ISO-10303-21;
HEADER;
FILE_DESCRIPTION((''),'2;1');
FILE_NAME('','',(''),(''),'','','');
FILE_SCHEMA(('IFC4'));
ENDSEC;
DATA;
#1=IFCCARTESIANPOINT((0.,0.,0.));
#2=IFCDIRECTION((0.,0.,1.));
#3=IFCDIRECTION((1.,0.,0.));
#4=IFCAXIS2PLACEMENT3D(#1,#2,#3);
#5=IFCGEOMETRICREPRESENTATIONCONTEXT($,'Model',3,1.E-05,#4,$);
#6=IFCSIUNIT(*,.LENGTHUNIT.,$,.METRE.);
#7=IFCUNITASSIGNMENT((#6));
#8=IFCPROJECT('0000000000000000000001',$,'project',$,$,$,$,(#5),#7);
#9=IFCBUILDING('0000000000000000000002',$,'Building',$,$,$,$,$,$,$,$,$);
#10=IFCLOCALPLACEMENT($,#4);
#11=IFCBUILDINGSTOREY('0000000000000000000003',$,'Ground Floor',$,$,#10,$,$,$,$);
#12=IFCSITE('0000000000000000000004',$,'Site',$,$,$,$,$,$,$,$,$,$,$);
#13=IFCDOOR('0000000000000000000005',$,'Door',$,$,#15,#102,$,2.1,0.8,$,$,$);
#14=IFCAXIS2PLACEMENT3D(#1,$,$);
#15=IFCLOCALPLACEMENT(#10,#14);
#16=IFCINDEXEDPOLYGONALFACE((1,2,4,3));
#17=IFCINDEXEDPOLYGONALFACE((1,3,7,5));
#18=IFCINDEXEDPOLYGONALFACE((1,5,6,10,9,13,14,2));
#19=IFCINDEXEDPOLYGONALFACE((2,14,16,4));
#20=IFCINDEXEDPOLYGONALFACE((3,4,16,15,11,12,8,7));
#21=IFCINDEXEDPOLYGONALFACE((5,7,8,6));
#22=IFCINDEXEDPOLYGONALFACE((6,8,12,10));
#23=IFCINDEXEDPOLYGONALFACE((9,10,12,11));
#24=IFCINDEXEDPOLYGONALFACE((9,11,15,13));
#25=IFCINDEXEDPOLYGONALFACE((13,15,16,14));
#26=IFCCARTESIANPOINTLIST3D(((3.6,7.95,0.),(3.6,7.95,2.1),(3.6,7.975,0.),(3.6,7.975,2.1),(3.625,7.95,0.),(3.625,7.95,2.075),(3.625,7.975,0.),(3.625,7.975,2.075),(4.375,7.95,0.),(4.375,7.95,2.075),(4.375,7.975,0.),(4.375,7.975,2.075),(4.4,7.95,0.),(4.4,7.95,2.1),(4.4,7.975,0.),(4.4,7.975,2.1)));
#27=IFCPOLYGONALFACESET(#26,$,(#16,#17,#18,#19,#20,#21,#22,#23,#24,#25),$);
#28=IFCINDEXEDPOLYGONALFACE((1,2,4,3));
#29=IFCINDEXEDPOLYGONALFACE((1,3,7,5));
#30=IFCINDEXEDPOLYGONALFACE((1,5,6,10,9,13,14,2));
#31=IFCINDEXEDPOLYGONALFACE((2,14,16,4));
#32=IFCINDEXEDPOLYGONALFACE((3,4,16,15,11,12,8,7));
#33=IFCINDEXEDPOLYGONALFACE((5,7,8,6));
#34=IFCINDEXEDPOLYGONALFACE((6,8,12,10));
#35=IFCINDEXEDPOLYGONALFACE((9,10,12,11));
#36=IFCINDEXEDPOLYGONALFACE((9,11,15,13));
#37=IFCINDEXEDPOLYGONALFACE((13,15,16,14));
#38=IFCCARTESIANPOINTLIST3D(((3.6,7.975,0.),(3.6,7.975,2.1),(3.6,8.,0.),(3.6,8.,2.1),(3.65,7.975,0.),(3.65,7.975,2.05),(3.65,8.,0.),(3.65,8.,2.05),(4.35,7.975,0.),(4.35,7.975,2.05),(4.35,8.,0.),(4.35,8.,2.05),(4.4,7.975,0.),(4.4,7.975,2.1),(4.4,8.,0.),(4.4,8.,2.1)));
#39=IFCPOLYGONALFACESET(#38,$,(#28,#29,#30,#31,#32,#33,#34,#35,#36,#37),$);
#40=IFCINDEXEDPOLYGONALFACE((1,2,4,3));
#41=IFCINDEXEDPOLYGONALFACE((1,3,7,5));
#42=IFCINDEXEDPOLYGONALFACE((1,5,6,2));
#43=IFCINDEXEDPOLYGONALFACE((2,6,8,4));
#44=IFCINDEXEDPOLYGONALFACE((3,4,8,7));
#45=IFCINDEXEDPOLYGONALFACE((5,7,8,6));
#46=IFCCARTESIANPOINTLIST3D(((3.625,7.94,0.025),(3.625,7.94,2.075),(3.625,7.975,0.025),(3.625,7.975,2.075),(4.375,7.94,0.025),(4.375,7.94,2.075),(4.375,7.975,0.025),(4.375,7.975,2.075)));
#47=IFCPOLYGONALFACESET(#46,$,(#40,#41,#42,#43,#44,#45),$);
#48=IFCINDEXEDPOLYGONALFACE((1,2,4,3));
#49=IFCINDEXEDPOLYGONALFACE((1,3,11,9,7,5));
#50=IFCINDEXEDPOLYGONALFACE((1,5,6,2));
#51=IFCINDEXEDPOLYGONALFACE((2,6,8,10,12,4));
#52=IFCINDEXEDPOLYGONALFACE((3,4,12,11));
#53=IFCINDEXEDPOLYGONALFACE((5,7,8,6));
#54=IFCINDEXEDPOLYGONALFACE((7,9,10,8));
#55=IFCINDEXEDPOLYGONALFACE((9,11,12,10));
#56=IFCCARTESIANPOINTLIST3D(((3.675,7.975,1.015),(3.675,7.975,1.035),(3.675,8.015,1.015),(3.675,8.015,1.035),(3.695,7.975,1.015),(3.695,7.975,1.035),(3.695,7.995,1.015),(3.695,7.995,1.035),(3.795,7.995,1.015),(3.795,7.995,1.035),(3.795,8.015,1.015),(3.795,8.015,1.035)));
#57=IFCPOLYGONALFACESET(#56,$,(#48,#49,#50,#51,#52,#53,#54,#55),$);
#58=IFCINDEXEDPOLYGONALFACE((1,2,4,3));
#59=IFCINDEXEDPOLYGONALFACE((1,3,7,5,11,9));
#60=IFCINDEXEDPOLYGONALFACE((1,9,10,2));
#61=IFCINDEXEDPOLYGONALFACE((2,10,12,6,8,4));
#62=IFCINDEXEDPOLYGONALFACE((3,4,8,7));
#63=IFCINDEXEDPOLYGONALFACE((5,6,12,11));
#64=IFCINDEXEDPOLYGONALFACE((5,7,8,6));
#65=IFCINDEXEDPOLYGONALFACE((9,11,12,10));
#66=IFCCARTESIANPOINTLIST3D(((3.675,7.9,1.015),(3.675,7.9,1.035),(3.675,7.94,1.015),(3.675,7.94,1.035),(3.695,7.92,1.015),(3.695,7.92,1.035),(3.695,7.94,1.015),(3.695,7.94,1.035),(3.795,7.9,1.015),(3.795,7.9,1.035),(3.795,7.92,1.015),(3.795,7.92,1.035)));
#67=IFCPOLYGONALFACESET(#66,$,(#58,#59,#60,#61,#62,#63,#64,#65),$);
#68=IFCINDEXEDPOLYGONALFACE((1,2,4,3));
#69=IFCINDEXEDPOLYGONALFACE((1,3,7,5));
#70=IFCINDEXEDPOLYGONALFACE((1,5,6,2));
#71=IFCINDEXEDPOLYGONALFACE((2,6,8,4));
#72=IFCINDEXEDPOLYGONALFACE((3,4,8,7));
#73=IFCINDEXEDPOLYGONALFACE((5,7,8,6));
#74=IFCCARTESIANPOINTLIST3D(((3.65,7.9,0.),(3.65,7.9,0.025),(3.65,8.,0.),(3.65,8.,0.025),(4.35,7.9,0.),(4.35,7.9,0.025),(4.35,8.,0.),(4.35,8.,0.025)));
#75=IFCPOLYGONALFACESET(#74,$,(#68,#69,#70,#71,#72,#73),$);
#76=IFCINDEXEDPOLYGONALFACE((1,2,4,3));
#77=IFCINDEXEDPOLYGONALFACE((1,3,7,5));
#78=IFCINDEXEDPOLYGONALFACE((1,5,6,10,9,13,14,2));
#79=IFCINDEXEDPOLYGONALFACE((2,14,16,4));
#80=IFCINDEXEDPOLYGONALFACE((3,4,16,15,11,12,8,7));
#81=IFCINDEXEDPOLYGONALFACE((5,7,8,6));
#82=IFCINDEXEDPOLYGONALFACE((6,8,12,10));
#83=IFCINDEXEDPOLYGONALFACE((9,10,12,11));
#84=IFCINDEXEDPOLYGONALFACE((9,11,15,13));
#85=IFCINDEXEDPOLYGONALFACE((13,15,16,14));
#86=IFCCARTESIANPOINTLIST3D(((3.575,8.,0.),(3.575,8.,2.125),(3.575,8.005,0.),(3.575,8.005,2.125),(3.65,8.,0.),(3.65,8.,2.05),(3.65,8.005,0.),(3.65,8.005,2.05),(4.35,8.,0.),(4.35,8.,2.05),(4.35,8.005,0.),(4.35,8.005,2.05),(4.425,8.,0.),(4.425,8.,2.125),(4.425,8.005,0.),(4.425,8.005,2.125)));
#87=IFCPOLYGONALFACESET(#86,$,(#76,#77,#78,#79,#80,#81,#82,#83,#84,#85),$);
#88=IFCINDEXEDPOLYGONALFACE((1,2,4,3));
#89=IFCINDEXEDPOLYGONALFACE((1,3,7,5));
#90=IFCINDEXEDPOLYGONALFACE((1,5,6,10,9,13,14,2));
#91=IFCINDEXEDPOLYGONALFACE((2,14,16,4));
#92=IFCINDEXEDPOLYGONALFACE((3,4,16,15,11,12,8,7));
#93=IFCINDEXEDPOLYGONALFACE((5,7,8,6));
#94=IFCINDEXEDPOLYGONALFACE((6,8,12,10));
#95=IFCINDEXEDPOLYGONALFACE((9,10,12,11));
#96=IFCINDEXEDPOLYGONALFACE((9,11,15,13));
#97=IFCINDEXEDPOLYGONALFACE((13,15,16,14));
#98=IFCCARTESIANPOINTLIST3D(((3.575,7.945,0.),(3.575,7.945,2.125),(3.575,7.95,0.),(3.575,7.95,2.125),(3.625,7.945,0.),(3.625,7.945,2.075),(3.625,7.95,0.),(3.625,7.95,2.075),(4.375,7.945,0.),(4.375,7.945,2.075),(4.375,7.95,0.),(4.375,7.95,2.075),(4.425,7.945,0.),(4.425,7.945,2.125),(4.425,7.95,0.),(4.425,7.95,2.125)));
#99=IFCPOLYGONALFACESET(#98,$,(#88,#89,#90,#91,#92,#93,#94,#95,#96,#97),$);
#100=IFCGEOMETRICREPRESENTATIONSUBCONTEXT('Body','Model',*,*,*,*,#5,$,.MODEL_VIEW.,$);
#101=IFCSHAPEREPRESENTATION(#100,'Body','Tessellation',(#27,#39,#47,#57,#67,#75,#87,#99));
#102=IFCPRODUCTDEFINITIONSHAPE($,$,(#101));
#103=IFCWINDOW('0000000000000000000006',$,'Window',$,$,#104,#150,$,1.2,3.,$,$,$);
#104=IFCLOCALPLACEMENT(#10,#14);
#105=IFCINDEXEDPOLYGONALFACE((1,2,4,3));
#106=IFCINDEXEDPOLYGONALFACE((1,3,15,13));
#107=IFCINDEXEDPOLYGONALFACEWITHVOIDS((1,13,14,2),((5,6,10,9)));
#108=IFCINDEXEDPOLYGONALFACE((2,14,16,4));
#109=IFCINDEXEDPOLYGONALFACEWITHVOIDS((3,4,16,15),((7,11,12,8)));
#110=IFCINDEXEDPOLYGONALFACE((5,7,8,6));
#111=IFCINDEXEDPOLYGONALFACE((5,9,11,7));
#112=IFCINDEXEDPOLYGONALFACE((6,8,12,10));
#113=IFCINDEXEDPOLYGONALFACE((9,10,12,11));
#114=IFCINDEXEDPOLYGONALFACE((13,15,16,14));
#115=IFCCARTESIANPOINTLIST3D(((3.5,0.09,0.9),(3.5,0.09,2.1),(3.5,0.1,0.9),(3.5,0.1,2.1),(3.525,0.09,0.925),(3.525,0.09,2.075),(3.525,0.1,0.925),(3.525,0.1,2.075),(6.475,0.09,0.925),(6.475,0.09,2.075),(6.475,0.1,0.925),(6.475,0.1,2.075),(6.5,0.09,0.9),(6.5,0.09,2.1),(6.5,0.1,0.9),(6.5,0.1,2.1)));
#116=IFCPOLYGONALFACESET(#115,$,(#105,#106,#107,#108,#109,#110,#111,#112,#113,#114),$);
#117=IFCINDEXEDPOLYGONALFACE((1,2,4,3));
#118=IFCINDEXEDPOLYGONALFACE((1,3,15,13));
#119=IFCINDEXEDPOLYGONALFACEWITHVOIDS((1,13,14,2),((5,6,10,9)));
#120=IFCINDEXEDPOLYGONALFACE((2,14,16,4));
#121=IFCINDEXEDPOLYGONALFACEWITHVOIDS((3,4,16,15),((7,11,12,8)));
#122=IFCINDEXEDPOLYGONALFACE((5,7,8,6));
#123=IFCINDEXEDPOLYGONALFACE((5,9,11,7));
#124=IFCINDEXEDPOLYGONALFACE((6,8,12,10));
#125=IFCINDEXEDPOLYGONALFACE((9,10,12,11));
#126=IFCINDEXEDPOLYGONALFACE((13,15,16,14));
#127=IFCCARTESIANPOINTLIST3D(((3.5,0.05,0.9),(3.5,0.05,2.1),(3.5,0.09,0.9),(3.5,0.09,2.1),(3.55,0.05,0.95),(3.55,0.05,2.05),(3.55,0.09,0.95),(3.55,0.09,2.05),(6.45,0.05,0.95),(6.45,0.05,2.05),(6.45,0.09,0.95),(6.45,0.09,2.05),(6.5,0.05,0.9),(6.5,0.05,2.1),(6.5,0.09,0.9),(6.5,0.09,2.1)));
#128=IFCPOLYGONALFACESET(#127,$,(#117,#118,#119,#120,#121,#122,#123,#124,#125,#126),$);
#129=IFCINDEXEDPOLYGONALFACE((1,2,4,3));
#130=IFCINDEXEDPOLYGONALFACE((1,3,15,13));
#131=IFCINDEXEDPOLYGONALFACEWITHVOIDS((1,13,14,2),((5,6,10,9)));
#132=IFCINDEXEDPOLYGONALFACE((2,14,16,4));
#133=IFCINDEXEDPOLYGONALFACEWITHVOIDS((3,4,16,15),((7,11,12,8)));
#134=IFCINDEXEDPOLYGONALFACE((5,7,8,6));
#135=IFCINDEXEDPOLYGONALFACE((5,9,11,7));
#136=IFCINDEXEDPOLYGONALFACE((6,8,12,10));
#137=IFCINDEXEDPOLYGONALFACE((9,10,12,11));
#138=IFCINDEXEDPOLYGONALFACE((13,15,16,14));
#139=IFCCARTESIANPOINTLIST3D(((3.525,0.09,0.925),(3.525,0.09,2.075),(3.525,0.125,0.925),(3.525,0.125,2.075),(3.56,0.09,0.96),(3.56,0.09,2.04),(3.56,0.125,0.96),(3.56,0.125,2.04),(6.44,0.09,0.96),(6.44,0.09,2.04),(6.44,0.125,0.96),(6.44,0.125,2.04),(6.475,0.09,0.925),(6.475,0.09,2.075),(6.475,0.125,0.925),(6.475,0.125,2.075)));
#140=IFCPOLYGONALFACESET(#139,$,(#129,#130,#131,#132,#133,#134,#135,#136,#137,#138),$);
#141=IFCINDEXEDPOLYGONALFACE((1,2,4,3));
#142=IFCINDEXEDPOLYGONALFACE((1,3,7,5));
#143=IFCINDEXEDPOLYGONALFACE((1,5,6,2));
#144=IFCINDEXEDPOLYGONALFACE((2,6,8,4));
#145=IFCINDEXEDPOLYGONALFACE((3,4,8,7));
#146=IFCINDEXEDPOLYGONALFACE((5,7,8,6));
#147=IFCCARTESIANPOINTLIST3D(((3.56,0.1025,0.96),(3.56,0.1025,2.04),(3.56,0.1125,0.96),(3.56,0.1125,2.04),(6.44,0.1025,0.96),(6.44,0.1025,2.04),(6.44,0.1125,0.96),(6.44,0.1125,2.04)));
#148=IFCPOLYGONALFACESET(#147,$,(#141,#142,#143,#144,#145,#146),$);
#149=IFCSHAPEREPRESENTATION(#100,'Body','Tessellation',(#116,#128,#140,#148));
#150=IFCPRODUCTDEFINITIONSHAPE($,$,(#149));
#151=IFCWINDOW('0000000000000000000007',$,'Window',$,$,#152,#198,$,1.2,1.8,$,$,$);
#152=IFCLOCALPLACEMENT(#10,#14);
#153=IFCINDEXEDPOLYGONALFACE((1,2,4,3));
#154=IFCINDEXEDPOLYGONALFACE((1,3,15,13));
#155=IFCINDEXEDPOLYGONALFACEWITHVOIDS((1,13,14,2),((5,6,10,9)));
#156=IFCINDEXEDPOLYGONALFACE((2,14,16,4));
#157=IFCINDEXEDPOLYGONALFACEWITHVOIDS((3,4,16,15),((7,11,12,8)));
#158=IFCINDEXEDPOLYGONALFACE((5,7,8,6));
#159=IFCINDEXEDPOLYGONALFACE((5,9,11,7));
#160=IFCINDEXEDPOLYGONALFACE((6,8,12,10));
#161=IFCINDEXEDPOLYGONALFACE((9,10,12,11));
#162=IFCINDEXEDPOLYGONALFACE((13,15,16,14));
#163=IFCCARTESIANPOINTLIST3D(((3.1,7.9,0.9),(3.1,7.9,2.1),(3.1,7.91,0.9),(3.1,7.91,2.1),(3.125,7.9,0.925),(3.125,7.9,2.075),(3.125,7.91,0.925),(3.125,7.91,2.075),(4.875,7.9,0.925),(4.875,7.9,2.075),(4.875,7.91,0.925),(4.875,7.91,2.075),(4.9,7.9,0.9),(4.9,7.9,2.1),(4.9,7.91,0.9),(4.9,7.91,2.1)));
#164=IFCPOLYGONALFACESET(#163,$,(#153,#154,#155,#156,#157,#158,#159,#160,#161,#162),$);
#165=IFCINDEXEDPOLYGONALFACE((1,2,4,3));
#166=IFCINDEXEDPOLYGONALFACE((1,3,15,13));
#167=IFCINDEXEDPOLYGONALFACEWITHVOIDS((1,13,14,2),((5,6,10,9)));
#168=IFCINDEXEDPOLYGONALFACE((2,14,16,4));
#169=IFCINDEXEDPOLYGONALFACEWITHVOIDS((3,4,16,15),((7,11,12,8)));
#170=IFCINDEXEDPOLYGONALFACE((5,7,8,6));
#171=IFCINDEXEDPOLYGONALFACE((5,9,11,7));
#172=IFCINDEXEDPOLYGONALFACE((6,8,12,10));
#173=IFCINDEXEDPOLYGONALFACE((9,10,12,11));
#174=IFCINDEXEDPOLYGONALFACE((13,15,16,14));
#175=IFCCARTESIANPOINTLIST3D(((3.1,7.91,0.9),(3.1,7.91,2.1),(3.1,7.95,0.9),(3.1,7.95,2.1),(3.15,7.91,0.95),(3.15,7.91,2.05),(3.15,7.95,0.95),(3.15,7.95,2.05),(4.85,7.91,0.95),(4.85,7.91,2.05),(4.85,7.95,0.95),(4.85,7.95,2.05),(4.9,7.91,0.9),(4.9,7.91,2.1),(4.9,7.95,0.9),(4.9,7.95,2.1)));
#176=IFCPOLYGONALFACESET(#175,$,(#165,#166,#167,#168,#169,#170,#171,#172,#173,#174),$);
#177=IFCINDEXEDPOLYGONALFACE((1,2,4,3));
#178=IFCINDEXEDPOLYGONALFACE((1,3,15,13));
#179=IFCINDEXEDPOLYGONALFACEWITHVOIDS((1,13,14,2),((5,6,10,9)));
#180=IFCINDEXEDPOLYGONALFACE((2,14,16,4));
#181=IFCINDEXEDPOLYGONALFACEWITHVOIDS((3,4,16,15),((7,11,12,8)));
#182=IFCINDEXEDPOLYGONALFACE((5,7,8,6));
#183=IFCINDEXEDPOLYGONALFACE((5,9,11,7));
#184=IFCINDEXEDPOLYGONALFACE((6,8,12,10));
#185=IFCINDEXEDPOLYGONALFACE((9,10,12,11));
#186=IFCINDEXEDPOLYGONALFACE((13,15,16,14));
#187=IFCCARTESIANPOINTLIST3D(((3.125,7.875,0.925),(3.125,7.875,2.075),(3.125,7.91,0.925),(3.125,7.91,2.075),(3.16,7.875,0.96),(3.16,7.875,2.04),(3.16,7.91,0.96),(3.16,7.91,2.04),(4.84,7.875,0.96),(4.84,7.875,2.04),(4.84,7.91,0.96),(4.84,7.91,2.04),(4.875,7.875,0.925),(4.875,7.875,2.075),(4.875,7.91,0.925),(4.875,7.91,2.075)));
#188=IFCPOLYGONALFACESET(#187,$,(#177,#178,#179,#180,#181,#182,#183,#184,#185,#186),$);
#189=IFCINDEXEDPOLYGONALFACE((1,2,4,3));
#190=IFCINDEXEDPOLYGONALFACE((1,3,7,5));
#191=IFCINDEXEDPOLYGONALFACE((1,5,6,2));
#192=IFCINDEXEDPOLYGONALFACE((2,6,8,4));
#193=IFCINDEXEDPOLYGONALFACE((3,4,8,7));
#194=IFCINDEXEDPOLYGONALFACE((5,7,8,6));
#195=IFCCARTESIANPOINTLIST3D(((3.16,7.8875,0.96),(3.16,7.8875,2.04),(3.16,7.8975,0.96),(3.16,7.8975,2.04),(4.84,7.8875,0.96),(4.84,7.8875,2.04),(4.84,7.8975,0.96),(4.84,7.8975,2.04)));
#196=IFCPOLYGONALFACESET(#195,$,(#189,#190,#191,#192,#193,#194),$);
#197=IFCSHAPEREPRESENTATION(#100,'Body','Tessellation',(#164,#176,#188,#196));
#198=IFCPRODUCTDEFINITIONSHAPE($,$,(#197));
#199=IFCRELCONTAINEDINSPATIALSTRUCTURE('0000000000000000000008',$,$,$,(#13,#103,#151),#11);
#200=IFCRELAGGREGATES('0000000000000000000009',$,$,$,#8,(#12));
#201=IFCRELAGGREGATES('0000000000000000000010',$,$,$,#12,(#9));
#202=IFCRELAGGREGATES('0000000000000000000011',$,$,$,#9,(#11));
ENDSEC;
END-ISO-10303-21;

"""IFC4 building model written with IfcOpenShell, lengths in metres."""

from ifc_helpers import new_model, si_unit, frame, origin_with_axes, place, context, subcontext, project, spatial, line, indexed_curve, outline, extrude, element, save


model = new_model("IFC4")

# Units and contexts
model_context = context("Model", 3, precision=1e-05, world=origin_with_axes())
body_context = subcontext(model_context, "Body", "Model", "MODEL_VIEW")
ifc_project = project(units=[si_unit("LENGTHUNIT", "METRE")], contexts=[model_context])

# Site, building, storey
site = spatial("IfcSite", under=ifc_project, Name="Site")
building = spatial("IfcBuilding", under=site, Name="Building")
storey_placement = place(None, origin_with_axes())
storey = spatial("IfcBuildingStorey", under=building, at=storey_placement, Name="Ground Floor")

# Door
door_1_placement = place(storey_placement, frame((4.4, 8.0, 0.0), z_axis=(0.0, 0.0, 1.0), x_axis=(-1.0, 0.0, 0.0)))
element("IfcDoor", 1, at=door_1_placement, inside=storey, Name="Door", OverallHeight=2.1, OverallWidth=0.8, context=body_context, shape_type="SweptSolid", body=[
    extrude(outline(indexed_curve([(0.0, 0.0), (0.0, 2.1), (0.8, 2.1), (0.8, 0.0), (0.775, 0.0), (0.775, 2.075), (0.025, 2.075), (0.025, 0.0)], segments=[line(1, 2, 3, 4, 5, 6, 7, 8, 1)])), frame((0.0, 0.025, 0.0), z_axis=(0.0, -1.0, 0.0), x_axis=(1.0, 0.0, 0.0)), (0.0, 0.0, -1.0), 0.025),
    extrude(outline(indexed_curve([(0.0, 0.0), (0.0, 2.1), (0.8, 2.1), (0.8, 0.0), (0.75, 0.0), (0.75, 2.05), (0.05, 2.05), (0.05, 0.0)], segments=[line(1, 2, 3, 4, 5, 6, 7, 8, 1)])), frame((0.0, 0.0, 0.0), z_axis=(0.0, -1.0, 0.0), x_axis=(1.0, 0.0, 0.0)), (0.0, 0.0, -1.0), 0.025),
    extrude(outline(indexed_curve([(0.0, 0.0), (0.75, 0.0), (0.75, 0.035), (0.0, 0.035)], segments=[line(1, 2, 3, 4, 1)])), frame((0.025, 0.025, 0.025), z_axis=(0.0, 0.0, 1.0), x_axis=(1.0, 0.0, 0.0)), (0.0, 0.0, 1.0), 2.05),
    extrude(outline(indexed_curve([(0.0, 0.0), (0.0, -0.04), (-0.12, -0.04), (-0.12, -0.02), (-0.02, -0.02), (-0.02, 0.0)], segments=[line(1, 2, 3, 4, 5, 6, 1)])), frame((0.725, 0.025, 1.015), z_axis=(0.0, 0.0, 1.0), x_axis=(1.0, 0.0, 0.0)), (0.0, 0.0, 1.0), 0.02),
    extrude(outline(indexed_curve([(0.0, 0.0), (0.0, 0.04), (-0.12, 0.04), (-0.12, 0.02), (-0.02, 0.02), (-0.02, 0.0)], segments=[line(1, 2, 3, 4, 5, 6, 1)])), frame((0.725, 0.06, 1.015), z_axis=(0.0, 0.0, 1.0), x_axis=(1.0, 0.0, 0.0)), (0.0, 0.0, 1.0), 0.02),
    extrude(outline(indexed_curve([(0.0, 0.0), (0.7, 0.0), (0.7, 0.1), (0.0, 0.1)], segments=[line(1, 2, 3, 4, 1)])), frame((0.05, 0.0, 0.0), z_axis=(0.0, 0.0, 1.0), x_axis=(1.0, 0.0, 0.0)), (0.0, 0.0, 1.0), 0.025),
    extrude(outline(indexed_curve([(0.0, 0.0), (0.0, 2.125), (0.85, 2.125), (0.85, 0.0), (0.775, 0.0), (0.775, 2.05), (0.075, 2.05), (0.075, 0.0)], segments=[line(1, 2, 3, 4, 5, 6, 7, 8, 1)])), frame((-0.025, -0.005, 0.0), z_axis=(0.0, -1.0, 0.0), x_axis=(1.0, 0.0, 0.0)), (0.0, 0.0, -1.0), 0.005),
    extrude(outline(indexed_curve([(0.0, 0.0), (0.0, 2.125), (0.85, 2.125), (0.85, 0.0), (0.8, 0.0), (0.8, 2.075), (0.05, 2.075), (0.05, 0.0)], segments=[line(1, 2, 3, 4, 5, 6, 7, 8, 1)])), frame((-0.025, 0.05, 0.0), z_axis=(0.0, -1.0, 0.0), x_axis=(1.0, 0.0, 0.0)), (0.0, 0.0, -1.0), 0.005),
])

# Windows
window_1_placement = place(storey_placement, frame((3.5, 0.0, 0.9), z_axis=(0.0, 0.0, 1.0), x_axis=(1.0, 0.0, 0.0)))
element("IfcWindow", 2, at=window_1_placement, inside=storey, Name="Window", OverallHeight=1.2, OverallWidth=3.0, context=body_context, shape_type="SweptSolid", body=[
    extrude(outline(indexed_curve([(0.0, 0.0), (3.0, 0.0), (3.0, 1.2), (0.0, 1.2)], segments=[line(1, 2, 3, 4, 1)]), holes=[indexed_curve([(0.025, 0.025), (2.975, 0.025), (2.975, 1.175), (0.025, 1.175)], segments=[line(1, 2, 3, 4, 1)])]), frame((0.0, 0.09, 0.0), z_axis=(0.0, -1.0, 0.0), x_axis=(1.0, 0.0, 0.0)), (0.0, 0.0, -1.0), 0.01),
    extrude(outline(indexed_curve([(0.0, 0.0), (3.0, 0.0), (3.0, 1.2), (0.0, 1.2)], segments=[line(1, 2, 3, 4, 1)]), holes=[indexed_curve([(0.05, 0.05), (2.95, 0.05), (2.95, 1.15), (0.05, 1.15)], segments=[line(1, 2, 3, 4, 1)])]), frame((0.0, 0.05, 0.0), z_axis=(0.0, -1.0, 0.0), x_axis=(1.0, 0.0, 0.0)), (0.0, 0.0, -1.0), 0.04),
    extrude(outline(indexed_curve([(0.0, 0.0), (2.95, 0.0), (2.95, 1.15), (0.0, 1.15)], segments=[line(1, 2, 3, 4, 1)]), holes=[indexed_curve([(0.035, 0.035), (2.915, 0.035), (2.915, 1.115), (0.035, 1.115)], segments=[line(1, 2, 3, 4, 1)])]), frame((0.025, 0.09, 0.025), z_axis=(0.0, -1.0, 0.0), x_axis=(1.0, 0.0, 0.0)), (0.0, 0.0, -1.0), 0.035),
    extrude(outline(indexed_curve([(0.035, 0.035), (2.915, 0.035), (2.915, 1.115), (0.035, 1.115)], segments=[line(1, 2, 3, 4, 1)])), frame((0.025, 0.1025, 0.025), z_axis=(0.0, -1.0, 0.0), x_axis=(1.0, 0.0, 0.0)), (0.0, 0.0, -1.0), 0.01),
])
window_2_placement = place(storey_placement, frame((4.9, 8.0, 0.9), z_axis=(0.0, 0.0, 1.0), x_axis=(-1.0, 0.0, 0.0)))
element("IfcWindow", 3, at=window_2_placement, inside=storey, Name="Window", OverallHeight=1.2, OverallWidth=1.8, context=body_context, shape_type="SweptSolid", body=[
    extrude(outline(indexed_curve([(0.0, 0.0), (1.8, 0.0), (1.8, 1.2), (0.0, 1.2)], segments=[line(1, 2, 3, 4, 1)]), holes=[indexed_curve([(0.025, 0.025), (1.775, 0.025), (1.775, 1.175), (0.025, 1.175)], segments=[line(1, 2, 3, 4, 1)])]), frame((0.0, 0.09, 0.0), z_axis=(0.0, -1.0, 0.0), x_axis=(1.0, 0.0, 0.0)), (0.0, 0.0, -1.0), 0.01),
    extrude(outline(indexed_curve([(0.0, 0.0), (1.8, 0.0), (1.8, 1.2), (0.0, 1.2)], segments=[line(1, 2, 3, 4, 1)]), holes=[indexed_curve([(0.05, 0.05), (1.75, 0.05), (1.75, 1.15), (0.05, 1.15)], segments=[line(1, 2, 3, 4, 1)])]), frame((0.0, 0.05, 0.0), z_axis=(0.0, -1.0, 0.0), x_axis=(1.0, 0.0, 0.0)), (0.0, 0.0, -1.0), 0.04),
    extrude(outline(indexed_curve([(0.0, 0.0), (1.75, 0.0), (1.75, 1.15), (0.0, 1.15)], segments=[line(1, 2, 3, 4, 1)]), holes=[indexed_curve([(0.035, 0.035), (1.715, 0.035), (1.715, 1.115), (0.035, 1.115)], segments=[line(1, 2, 3, 4, 1)])]), frame((0.025, 0.09, 0.025), z_axis=(0.0, -1.0, 0.0), x_axis=(1.0, 0.0, 0.0)), (0.0, 0.0, -1.0), 0.035),
    extrude(outline(indexed_curve([(0.035, 0.035), (1.715, 0.035), (1.715, 1.115), (0.035, 1.115)], segments=[line(1, 2, 3, 4, 1)])), frame((0.025, 0.1025, 0.025), z_axis=(0.0, -1.0, 0.0), x_axis=(1.0, 0.0, 0.0)), (0.0, 0.0, -1.0), 0.01),
])

save(model, "model.ifc")
